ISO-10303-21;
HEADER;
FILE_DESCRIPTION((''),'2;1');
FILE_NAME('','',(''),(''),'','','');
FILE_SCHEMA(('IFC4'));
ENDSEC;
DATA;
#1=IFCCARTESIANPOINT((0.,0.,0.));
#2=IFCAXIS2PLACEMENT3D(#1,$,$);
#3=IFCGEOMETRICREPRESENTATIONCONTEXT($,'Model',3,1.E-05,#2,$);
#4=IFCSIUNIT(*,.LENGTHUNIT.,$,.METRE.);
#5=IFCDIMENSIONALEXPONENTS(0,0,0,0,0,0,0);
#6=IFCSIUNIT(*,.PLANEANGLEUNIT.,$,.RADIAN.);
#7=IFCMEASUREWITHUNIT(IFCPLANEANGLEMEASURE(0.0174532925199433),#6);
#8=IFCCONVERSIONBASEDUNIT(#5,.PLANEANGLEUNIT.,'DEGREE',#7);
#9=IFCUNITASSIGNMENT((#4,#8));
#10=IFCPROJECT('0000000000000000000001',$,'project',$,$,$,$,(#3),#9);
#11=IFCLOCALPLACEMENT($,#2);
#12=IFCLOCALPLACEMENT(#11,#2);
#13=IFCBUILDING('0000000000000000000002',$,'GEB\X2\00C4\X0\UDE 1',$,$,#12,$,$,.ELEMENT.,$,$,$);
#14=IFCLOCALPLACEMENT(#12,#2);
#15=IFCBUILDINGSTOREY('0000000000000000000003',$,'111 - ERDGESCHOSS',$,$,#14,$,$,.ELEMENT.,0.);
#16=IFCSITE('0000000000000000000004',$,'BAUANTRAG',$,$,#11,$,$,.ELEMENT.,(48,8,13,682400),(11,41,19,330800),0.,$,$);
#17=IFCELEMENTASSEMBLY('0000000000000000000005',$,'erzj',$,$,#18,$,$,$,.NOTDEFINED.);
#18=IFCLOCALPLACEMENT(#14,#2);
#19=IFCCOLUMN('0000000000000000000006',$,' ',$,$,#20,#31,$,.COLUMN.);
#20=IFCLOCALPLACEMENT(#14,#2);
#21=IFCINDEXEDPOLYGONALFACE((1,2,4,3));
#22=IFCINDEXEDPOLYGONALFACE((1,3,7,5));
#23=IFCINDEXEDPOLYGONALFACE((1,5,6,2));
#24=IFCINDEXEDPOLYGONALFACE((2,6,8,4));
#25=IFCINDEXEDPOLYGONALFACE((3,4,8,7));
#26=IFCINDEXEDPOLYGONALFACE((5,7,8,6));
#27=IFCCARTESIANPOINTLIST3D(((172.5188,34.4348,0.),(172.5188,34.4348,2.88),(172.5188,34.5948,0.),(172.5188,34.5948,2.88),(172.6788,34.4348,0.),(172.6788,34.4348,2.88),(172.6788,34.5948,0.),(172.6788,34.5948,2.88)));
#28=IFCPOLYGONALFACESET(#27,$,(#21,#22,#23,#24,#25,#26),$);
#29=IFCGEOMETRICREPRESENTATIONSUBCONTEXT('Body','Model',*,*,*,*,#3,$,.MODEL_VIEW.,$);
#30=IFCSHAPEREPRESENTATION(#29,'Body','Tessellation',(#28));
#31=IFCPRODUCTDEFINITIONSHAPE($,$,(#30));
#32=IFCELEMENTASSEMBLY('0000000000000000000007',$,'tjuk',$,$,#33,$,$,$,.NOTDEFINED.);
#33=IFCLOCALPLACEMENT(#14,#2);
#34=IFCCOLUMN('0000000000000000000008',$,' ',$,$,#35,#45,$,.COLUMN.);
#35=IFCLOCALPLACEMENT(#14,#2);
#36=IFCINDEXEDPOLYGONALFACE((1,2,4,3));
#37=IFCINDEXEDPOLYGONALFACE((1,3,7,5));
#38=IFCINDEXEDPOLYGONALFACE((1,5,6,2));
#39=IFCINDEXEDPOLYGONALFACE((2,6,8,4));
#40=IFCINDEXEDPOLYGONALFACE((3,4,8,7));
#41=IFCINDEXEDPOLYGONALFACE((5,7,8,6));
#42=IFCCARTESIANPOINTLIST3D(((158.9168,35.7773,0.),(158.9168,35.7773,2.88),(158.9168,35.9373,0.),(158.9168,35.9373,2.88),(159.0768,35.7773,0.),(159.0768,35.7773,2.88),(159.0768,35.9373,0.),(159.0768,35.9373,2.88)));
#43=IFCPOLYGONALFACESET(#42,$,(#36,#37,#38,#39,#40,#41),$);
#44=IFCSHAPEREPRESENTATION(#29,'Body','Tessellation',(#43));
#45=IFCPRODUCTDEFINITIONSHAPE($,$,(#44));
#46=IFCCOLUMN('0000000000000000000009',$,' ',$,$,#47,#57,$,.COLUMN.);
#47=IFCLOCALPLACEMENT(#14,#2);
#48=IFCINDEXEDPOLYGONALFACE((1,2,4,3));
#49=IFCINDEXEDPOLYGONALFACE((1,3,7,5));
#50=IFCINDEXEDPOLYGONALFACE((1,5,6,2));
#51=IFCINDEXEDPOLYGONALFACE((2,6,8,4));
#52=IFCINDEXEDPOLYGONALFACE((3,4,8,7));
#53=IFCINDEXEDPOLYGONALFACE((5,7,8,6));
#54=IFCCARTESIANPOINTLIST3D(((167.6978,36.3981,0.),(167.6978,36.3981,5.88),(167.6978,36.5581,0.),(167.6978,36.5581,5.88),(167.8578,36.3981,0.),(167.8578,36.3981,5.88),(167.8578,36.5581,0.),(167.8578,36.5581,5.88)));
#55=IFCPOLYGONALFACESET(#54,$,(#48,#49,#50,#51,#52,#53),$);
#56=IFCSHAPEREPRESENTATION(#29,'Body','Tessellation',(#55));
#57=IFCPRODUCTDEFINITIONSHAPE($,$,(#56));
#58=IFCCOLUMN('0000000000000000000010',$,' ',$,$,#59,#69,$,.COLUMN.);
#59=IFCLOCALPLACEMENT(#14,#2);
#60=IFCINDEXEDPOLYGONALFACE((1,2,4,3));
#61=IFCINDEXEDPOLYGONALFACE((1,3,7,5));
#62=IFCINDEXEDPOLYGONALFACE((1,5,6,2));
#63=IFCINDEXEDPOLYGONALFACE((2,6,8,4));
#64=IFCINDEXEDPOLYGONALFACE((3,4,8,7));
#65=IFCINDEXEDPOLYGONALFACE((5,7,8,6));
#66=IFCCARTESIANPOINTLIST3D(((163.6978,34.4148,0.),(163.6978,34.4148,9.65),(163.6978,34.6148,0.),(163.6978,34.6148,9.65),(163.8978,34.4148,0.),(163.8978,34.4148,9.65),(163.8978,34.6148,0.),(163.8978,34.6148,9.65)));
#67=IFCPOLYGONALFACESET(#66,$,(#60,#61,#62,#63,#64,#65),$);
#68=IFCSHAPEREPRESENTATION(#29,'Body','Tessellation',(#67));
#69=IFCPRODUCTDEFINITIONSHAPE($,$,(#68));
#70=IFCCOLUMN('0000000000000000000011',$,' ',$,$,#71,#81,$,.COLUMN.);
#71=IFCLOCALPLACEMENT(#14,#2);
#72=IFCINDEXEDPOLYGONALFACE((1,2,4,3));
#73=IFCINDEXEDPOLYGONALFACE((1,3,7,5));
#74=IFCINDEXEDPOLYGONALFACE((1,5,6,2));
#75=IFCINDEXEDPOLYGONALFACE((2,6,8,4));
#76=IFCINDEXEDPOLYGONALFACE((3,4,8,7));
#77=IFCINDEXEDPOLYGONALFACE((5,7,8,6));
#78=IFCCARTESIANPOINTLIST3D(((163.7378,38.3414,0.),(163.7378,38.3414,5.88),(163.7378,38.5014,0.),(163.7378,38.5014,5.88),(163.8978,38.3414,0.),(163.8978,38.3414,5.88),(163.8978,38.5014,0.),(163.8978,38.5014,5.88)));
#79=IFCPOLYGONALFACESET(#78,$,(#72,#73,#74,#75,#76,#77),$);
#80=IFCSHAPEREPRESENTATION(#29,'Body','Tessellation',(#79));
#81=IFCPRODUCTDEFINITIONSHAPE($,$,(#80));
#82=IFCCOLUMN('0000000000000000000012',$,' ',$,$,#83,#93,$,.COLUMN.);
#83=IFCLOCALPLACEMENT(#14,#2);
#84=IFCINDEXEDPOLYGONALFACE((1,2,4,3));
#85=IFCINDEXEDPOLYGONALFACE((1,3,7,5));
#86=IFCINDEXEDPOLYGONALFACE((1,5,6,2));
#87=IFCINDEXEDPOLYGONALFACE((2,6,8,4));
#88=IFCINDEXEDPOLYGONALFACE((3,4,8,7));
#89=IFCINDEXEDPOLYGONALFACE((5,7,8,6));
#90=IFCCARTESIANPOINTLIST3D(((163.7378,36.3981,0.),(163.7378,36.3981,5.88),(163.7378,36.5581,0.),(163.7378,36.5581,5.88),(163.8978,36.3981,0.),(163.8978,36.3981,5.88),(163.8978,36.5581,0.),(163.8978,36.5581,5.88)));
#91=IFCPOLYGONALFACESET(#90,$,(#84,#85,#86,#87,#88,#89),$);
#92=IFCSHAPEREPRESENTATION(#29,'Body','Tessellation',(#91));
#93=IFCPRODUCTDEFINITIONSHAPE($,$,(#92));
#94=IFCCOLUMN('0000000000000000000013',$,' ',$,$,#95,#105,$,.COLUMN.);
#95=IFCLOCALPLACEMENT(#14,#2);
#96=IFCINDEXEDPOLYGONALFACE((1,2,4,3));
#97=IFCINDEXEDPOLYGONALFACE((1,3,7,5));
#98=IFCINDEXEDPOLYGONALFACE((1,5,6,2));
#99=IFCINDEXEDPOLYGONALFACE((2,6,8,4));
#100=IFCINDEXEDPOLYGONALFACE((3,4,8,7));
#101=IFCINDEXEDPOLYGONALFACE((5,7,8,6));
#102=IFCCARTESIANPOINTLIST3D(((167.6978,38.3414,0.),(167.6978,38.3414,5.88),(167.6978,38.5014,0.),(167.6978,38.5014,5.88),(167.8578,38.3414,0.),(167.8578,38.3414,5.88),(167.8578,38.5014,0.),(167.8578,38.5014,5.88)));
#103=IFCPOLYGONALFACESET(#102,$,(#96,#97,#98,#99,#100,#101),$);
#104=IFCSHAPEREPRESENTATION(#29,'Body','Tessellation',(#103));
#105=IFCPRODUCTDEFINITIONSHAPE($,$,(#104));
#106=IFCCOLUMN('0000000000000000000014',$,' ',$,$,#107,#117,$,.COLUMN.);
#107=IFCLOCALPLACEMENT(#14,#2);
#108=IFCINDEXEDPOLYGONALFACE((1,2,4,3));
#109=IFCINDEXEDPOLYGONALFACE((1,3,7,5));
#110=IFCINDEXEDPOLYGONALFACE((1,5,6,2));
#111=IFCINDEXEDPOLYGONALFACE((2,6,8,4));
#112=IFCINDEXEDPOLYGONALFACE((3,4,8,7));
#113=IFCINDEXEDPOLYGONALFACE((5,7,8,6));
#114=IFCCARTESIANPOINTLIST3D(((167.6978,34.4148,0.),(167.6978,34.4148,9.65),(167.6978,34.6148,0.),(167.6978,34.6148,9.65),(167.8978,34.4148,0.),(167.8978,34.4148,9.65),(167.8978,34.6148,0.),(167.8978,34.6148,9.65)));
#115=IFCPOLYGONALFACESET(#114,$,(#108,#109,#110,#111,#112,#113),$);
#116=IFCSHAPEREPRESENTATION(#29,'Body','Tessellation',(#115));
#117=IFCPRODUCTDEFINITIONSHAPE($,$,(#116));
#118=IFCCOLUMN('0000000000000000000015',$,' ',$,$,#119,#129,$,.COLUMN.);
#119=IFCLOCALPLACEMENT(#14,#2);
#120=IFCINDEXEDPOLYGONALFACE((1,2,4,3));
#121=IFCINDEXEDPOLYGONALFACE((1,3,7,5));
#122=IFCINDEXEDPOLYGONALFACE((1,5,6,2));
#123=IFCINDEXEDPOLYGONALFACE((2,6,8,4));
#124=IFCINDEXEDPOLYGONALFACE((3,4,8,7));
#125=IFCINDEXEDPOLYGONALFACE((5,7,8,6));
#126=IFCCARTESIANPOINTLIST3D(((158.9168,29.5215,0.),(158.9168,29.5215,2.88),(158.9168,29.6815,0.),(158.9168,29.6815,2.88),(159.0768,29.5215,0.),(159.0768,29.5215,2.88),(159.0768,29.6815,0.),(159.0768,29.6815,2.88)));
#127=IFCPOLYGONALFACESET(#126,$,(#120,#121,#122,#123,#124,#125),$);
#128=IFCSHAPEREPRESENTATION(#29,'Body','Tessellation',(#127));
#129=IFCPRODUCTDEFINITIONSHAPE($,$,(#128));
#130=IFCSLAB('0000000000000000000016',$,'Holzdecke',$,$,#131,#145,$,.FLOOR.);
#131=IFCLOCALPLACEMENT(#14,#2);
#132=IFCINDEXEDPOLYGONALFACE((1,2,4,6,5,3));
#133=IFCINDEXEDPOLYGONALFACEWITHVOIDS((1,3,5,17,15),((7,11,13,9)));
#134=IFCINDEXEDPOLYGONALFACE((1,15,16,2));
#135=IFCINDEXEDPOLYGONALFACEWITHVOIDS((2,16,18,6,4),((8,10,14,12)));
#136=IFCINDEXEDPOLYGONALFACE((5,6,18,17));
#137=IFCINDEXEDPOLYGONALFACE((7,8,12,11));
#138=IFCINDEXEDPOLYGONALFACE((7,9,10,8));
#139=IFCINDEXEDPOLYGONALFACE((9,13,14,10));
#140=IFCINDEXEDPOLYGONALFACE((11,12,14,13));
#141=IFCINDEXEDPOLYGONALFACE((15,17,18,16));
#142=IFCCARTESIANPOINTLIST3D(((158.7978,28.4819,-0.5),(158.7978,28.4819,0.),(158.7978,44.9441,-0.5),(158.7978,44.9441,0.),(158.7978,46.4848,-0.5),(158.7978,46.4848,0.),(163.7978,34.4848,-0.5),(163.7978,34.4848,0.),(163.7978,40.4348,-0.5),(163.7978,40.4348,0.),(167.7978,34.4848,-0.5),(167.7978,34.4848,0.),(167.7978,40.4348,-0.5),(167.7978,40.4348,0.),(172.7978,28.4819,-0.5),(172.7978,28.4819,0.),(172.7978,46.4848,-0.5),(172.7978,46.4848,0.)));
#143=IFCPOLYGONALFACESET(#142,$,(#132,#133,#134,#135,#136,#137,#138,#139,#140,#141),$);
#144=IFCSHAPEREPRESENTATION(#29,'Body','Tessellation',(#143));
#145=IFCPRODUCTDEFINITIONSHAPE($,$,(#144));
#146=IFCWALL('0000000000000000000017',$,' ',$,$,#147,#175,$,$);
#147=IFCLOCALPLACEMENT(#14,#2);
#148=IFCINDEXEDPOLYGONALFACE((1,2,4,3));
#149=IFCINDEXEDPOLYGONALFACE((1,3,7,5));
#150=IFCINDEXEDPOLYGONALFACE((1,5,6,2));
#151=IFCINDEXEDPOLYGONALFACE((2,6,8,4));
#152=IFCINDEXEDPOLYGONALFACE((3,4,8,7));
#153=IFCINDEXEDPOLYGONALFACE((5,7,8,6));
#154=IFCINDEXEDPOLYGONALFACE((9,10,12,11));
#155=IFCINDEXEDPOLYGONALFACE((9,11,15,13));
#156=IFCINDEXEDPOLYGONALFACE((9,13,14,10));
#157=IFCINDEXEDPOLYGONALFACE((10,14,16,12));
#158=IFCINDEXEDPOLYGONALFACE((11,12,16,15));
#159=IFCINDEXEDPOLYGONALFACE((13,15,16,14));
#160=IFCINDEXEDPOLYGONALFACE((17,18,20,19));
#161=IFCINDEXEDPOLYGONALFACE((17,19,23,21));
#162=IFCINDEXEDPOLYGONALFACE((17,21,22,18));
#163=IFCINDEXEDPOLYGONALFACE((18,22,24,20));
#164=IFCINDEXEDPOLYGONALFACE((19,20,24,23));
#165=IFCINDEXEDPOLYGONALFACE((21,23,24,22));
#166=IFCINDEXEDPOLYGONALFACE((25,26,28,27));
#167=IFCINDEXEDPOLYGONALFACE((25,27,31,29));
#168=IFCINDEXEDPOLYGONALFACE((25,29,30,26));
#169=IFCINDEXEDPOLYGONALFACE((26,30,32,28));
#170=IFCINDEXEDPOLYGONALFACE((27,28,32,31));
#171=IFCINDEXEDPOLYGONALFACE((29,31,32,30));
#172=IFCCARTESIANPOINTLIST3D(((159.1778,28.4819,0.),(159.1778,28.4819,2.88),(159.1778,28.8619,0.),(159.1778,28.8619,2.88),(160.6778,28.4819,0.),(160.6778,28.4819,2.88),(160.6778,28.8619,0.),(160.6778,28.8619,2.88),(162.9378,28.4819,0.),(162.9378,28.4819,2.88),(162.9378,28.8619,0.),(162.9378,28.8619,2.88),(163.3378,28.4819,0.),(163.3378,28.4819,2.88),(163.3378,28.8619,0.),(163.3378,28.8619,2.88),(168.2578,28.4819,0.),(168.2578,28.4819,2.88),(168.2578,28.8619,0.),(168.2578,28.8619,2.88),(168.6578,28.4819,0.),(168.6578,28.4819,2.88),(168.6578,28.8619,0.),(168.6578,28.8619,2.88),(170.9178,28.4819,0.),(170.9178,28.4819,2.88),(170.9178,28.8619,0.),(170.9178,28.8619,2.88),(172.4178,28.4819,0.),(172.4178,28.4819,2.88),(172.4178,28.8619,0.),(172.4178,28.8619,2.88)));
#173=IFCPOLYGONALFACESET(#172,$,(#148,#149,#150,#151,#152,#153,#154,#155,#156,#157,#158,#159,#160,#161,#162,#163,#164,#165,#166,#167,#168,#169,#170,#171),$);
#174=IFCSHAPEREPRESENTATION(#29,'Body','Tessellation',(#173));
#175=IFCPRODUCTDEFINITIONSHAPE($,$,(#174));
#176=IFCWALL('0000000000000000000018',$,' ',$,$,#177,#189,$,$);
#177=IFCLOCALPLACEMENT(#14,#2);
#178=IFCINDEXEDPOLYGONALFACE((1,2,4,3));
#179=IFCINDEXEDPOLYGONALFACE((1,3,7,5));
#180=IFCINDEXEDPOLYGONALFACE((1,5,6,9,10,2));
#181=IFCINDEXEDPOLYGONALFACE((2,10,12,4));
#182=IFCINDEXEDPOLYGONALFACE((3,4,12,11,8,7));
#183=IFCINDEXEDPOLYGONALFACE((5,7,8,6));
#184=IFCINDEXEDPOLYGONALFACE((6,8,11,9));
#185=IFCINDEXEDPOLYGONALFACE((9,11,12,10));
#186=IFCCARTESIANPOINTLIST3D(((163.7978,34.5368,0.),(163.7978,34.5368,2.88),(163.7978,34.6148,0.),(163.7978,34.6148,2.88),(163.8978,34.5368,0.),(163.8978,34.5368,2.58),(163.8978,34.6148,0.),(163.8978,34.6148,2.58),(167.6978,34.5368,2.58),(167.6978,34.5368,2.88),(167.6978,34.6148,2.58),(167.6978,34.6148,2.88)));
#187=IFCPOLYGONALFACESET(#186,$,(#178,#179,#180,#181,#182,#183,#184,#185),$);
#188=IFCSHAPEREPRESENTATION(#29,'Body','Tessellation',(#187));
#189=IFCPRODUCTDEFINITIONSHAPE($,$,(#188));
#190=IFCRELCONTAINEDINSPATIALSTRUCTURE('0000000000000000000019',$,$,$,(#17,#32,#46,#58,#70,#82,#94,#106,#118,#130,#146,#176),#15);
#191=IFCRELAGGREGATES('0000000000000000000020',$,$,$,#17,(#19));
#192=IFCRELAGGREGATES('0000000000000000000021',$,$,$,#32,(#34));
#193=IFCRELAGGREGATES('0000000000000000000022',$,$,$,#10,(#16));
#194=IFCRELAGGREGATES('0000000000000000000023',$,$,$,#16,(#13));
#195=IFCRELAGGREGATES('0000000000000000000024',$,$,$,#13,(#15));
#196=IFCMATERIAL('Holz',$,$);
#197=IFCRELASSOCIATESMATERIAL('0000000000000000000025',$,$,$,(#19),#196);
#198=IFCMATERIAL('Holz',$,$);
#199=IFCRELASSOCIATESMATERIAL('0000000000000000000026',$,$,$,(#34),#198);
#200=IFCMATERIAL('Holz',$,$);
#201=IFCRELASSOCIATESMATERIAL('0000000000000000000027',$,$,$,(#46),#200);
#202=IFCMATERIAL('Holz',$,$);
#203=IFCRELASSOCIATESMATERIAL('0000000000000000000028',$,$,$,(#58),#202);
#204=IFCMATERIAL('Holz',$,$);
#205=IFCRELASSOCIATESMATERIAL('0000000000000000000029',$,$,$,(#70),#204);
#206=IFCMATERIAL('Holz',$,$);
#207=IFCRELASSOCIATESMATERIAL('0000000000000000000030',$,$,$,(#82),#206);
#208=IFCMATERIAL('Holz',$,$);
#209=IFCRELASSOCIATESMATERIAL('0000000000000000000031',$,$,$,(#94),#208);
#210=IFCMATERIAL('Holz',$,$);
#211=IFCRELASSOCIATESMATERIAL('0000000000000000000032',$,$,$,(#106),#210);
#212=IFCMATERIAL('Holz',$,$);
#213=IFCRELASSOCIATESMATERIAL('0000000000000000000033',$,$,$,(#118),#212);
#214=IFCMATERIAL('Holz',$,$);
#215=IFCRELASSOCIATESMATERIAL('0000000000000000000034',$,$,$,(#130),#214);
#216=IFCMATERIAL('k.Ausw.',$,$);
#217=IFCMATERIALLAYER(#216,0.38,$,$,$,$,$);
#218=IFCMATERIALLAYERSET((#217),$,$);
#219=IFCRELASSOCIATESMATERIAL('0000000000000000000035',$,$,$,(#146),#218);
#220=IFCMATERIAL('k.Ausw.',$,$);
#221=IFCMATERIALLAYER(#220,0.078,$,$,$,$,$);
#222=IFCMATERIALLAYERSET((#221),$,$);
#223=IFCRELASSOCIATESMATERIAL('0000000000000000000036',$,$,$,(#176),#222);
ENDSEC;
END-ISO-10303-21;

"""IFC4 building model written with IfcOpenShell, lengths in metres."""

from ifc_helpers import new_model, entity, si_unit, converted_unit, frame, frame_2d, origin, origin_with_axes, place, context, subcontext, project, spatial, polyline, rectangle, outline, extrude, material, layer, layer_set, layer_usage, element, aggregate, save


model = new_model("IFC4")

# Units and contexts
model_context = context("Model", 3, precision=1e-05, world=origin())
body_context = subcontext(model_context, "Body", "Model", "MODEL_VIEW")
ifc_project = project(units=[si_unit("LENGTHUNIT", "METRE"), converted_unit("PLANEANGLEUNIT", "DEGREE", entity("IfcPlaneAngleMeasure", 0.0174532925199433), si_unit("PLANEANGLEUNIT", "RADIAN"), dimensions=[0, 0, 0, 0, 0, 0, 0])], contexts=[model_context])

# Site, building, storey
site_placement = place(None, origin())
site = spatial("IfcSite", under=ifc_project, at=site_placement, Name="BAUANTRAG", CompositionType="ELEMENT", RefLatitude=(48, 8, 13, 682400), RefLongitude=(11, 41, 19, 330800), RefElevation=0.0)
building_placement = place(site_placement, origin())
building = spatial("IfcBuilding", under=site, at=building_placement, Name="GEBÄUDE 1", CompositionType="ELEMENT")
storey_placement = place(building_placement, origin())
storey = spatial("IfcBuildingStorey", under=building, at=storey_placement, Name="111 - ERDGESCHOSS", CompositionType="ELEMENT", Elevation=0.0)

# Element assemblies, columns
assembly_1_placement = place(storey_placement, origin())
assembly_1 = element("IfcElementAssembly", 1, at=assembly_1_placement, inside=storey, Name="erzj", PredefinedType="NOTDEFINED")
ifc_material_1 = material(Name="Holz")
column_1_placement = place(assembly_1_placement, frame((172.5188, 34.4348, 0.0)))
column_1 = element("IfcColumn", 2, at=column_1_placement, material=ifc_material_1, Name=" ", PredefinedType="COLUMN", context=body_context, shape_type="SweptSolid", body=[
    extrude(rectangle(XDim=0.16, YDim=0.16, at=frame_2d((0.08, 0.08), x_axis=(1.0, 0.0))), origin_with_axes(), (0.0, 0.0, 1.0), 2.88),
])
aggregate(assembly_1, [column_1])
assembly_2_placement = place(storey_placement, origin())
assembly_2 = element("IfcElementAssembly", 3, at=assembly_2_placement, inside=storey, Name="tjuk", PredefinedType="NOTDEFINED")
ifc_material_2 = material(Name="Holz")
column_2_placement = place(assembly_2_placement, frame((158.9168, 35.7773, 0.0)))
column_2 = element("IfcColumn", 4, at=column_2_placement, material=ifc_material_2, Name=" ", PredefinedType="COLUMN", context=body_context, shape_type="SweptSolid", body=[
    extrude(rectangle(XDim=0.16, YDim=0.16, at=frame_2d((0.08, 0.08), x_axis=(1.0, 0.0))), origin_with_axes(), (0.0, 0.0, 1.0), 2.88),
])
aggregate(assembly_2, [column_2])

# Columns
ifc_material_3 = material(Name="Holz")
column_3_placement = place(storey_placement, frame((167.6978, 36.3981, 0.0)))
element("IfcColumn", 5, at=column_3_placement, inside=storey, material=ifc_material_3, Name=" ", PredefinedType="COLUMN", context=body_context, shape_type="SweptSolid", body=[
    extrude(rectangle(XDim=0.16, YDim=0.16, at=frame_2d((0.08, 0.08), x_axis=(1.0, 0.0))), origin_with_axes(), (0.0, 0.0, 1.0), 5.88),
])
ifc_material_4 = material(Name="Holz")
column_4_placement = place(storey_placement, frame((163.6978, 34.4148, 0.0)))
element("IfcColumn", 6, at=column_4_placement, inside=storey, material=ifc_material_4, Name=" ", PredefinedType="COLUMN", context=body_context, shape_type="SweptSolid", body=[
    extrude(rectangle(XDim=0.2, YDim=0.2, at=frame_2d((0.1, 0.1), x_axis=(1.0, 0.0))), origin_with_axes(), (0.0, 0.0, 1.0), 9.65),
])
ifc_material_5 = material(Name="Holz")
column_5_placement = place(storey_placement, frame((163.7378, 38.3414, 0.0)))
element("IfcColumn", 7, at=column_5_placement, inside=storey, material=ifc_material_5, Name=" ", PredefinedType="COLUMN", context=body_context, shape_type="SweptSolid", body=[
    extrude(rectangle(XDim=0.16, YDim=0.16, at=frame_2d((0.08, 0.08), x_axis=(1.0, 0.0))), origin_with_axes(), (0.0, 0.0, 1.0), 5.88),
])
ifc_material_6 = material(Name="Holz")
column_6_placement = place(storey_placement, frame((163.7378, 36.3981, 0.0)))
element("IfcColumn", 8, at=column_6_placement, inside=storey, material=ifc_material_6, Name=" ", PredefinedType="COLUMN", context=body_context, shape_type="SweptSolid", body=[
    extrude(rectangle(XDim=0.16, YDim=0.16, at=frame_2d((0.08, 0.08), x_axis=(1.0, 0.0))), origin_with_axes(), (0.0, 0.0, 1.0), 5.88),
])
ifc_material_7 = material(Name="Holz")
column_7_placement = place(storey_placement, frame((167.6978, 38.3414, 0.0)))
element("IfcColumn", 9, at=column_7_placement, inside=storey, material=ifc_material_7, Name=" ", PredefinedType="COLUMN", context=body_context, shape_type="SweptSolid", body=[
    extrude(rectangle(XDim=0.16, YDim=0.16, at=frame_2d((0.08, 0.08), x_axis=(1.0, 0.0))), origin_with_axes(), (0.0, 0.0, 1.0), 5.88),
])
ifc_material_8 = material(Name="Holz")
column_8_placement = place(storey_placement, frame((167.6978, 34.4148, 0.0)))
element("IfcColumn", 10, at=column_8_placement, inside=storey, material=ifc_material_8, Name=" ", PredefinedType="COLUMN", context=body_context, shape_type="SweptSolid", body=[
    extrude(rectangle(XDim=0.2, YDim=0.2, at=frame_2d((0.1, 0.1), x_axis=(1.0, 0.0))), origin_with_axes(), (0.0, 0.0, 1.0), 9.65),
])
ifc_material_9 = material(Name="Holz")
column_9_placement = place(storey_placement, frame((158.9168, 29.5215, 0.0)))
element("IfcColumn", 11, at=column_9_placement, inside=storey, material=ifc_material_9, Name=" ", PredefinedType="COLUMN", context=body_context, shape_type="SweptSolid", body=[
    extrude(rectangle(XDim=0.16, YDim=0.16, at=frame_2d((0.08, 0.08), x_axis=(1.0, 0.0))), origin_with_axes(), (0.0, 0.0, 1.0), 2.88),
])

# Slab
ifc_material_10 = material(Name="Holz")
slab_1_placement = place(storey_placement, frame((158.7978, 28.4819, -0.5)))
element("IfcSlab", 12, at=slab_1_placement, inside=storey, material=ifc_material_10, Name="Holzdecke", PredefinedType="FLOOR", context=body_context, shape_type="SweptSolid", body=[
    extrude(outline(polyline([(0.0, 16.4622), (0.0, 0.0), (14.0, 0.0), (14.0, 18.0029), (0.0, 18.0029), (0.0, 16.4622)]), holes=[polyline([(5.0, 11.9529), (9.0, 11.9529), (9.0, 6.0029), (5.0, 6.0029), (5.0, 11.9529)])]), origin_with_axes(), (0.0, 0.0, 1.0), 0.5),
])

# Wall, openings
ifc_material_11 = material(Name="k.Ausw.")
ifc_layer_1 = layer(ifc_material_11, 0.38)
ifc_layer_set_1 = layer_set([ifc_layer_1])
ifc_layer_usage_1 = layer_usage(ifc_layer_set_1, "AXIS2", "POSITIVE", 0.0)
wall_1_placement = place(storey_placement, frame((159.1778, 28.4819, 0.0)))
wall_1 = element("IfcWall", 13, at=wall_1_placement, inside=storey, material=ifc_layer_usage_1, Name=" ", context=body_context, shape_type="SweptSolid", body=[
    extrude(rectangle(XDim=13.24, YDim=0.38, at=frame_2d((6.62, 0.19), x_axis=(1.0, 0.0))), origin_with_axes(), (0.0, 0.0, 1.0), 2.88),
])
opening_1_placement = place(wall_1_placement, frame((9.48, 0.0, 0.0), z_axis=(0.0, 1.0, 0.0), x_axis=(0.0, 0.0, 1.0)))
element("IfcOpeningElement", 14, at=opening_1_placement, cuts=wall_1, ObjectType="Opening", context=body_context, shape_type="SweptSolid", body=[
    extrude(outline(polyline([(0.0, 2.26), (2.88, 2.26), (2.88, 0.0), (0.0, 0.0), (0.0, 2.26)])), origin_with_axes(), (0.0, 0.0, 1.0), 0.38),
])
opening_2_placement = place(wall_1_placement, frame((1.5, 0.0, 0.0), z_axis=(0.0, 1.0, 0.0), x_axis=(0.0, 0.0, 1.0)))
element("IfcOpeningElement", 15, at=opening_2_placement, cuts=wall_1, ObjectType="Opening", context=body_context, shape_type="SweptSolid", body=[
    extrude(outline(polyline([(0.0, 2.26), (2.88, 2.26), (2.88, 0.0), (0.0, 0.0), (0.0, 2.26)])), origin_with_axes(), (0.0, 0.0, 1.0), 0.38),
])
opening_3_placement = place(wall_1_placement, frame((4.16, 0.0, 0.0), z_axis=(0.0, 1.0, 0.0), x_axis=(0.0, 0.0, 1.0)))
element("IfcOpeningElement", 16, at=opening_3_placement, cuts=wall_1, ObjectType="Opening", context=body_context, shape_type="SweptSolid", body=[
    extrude(outline(polyline([(0.0, 4.92), (2.88, 4.92), (2.88, 0.0), (0.0, 0.0), (0.0, 4.92)])), origin_with_axes(), (0.0, 0.0, 1.0), 0.38),
])

# Wall, opening
ifc_material_12 = material(Name="k.Ausw.")
ifc_layer_2 = layer(ifc_material_12, 0.078)
ifc_layer_set_2 = layer_set([ifc_layer_2])
ifc_layer_usage_2 = layer_usage(ifc_layer_set_2, "AXIS2", "POSITIVE", 0.0)
wall_2_placement = place(storey_placement, frame((163.7978, 34.5368, 0.0)))
wall_2 = element("IfcWall", 17, at=wall_2_placement, inside=storey, material=ifc_layer_usage_2, Name=" ", context=body_context, shape_type="SweptSolid", body=[
    extrude(rectangle(XDim=3.9, YDim=0.078, at=frame_2d((1.95, 0.039), x_axis=(1.0, 0.0))), origin_with_axes(), (0.0, 0.0, 1.0), 2.88),
])
opening_4_placement = place(wall_2_placement, frame((0.1, 0.0, -0.14), z_axis=(0.0, 1.0, 0.0), x_axis=(0.0, 0.0, 1.0)))
element("IfcOpeningElement", 18, at=opening_4_placement, cuts=wall_2, ObjectType="Opening", context=body_context, shape_type="SweptSolid", body=[
    extrude(outline(polyline([(0.0, 3.8), (2.72, 3.8), (2.72, 0.0), (0.0, 0.0), (0.0, 3.8)])), origin_with_axes(), (0.0, 0.0, 1.0), 0.078),
])

save(model, "model.ifc")
